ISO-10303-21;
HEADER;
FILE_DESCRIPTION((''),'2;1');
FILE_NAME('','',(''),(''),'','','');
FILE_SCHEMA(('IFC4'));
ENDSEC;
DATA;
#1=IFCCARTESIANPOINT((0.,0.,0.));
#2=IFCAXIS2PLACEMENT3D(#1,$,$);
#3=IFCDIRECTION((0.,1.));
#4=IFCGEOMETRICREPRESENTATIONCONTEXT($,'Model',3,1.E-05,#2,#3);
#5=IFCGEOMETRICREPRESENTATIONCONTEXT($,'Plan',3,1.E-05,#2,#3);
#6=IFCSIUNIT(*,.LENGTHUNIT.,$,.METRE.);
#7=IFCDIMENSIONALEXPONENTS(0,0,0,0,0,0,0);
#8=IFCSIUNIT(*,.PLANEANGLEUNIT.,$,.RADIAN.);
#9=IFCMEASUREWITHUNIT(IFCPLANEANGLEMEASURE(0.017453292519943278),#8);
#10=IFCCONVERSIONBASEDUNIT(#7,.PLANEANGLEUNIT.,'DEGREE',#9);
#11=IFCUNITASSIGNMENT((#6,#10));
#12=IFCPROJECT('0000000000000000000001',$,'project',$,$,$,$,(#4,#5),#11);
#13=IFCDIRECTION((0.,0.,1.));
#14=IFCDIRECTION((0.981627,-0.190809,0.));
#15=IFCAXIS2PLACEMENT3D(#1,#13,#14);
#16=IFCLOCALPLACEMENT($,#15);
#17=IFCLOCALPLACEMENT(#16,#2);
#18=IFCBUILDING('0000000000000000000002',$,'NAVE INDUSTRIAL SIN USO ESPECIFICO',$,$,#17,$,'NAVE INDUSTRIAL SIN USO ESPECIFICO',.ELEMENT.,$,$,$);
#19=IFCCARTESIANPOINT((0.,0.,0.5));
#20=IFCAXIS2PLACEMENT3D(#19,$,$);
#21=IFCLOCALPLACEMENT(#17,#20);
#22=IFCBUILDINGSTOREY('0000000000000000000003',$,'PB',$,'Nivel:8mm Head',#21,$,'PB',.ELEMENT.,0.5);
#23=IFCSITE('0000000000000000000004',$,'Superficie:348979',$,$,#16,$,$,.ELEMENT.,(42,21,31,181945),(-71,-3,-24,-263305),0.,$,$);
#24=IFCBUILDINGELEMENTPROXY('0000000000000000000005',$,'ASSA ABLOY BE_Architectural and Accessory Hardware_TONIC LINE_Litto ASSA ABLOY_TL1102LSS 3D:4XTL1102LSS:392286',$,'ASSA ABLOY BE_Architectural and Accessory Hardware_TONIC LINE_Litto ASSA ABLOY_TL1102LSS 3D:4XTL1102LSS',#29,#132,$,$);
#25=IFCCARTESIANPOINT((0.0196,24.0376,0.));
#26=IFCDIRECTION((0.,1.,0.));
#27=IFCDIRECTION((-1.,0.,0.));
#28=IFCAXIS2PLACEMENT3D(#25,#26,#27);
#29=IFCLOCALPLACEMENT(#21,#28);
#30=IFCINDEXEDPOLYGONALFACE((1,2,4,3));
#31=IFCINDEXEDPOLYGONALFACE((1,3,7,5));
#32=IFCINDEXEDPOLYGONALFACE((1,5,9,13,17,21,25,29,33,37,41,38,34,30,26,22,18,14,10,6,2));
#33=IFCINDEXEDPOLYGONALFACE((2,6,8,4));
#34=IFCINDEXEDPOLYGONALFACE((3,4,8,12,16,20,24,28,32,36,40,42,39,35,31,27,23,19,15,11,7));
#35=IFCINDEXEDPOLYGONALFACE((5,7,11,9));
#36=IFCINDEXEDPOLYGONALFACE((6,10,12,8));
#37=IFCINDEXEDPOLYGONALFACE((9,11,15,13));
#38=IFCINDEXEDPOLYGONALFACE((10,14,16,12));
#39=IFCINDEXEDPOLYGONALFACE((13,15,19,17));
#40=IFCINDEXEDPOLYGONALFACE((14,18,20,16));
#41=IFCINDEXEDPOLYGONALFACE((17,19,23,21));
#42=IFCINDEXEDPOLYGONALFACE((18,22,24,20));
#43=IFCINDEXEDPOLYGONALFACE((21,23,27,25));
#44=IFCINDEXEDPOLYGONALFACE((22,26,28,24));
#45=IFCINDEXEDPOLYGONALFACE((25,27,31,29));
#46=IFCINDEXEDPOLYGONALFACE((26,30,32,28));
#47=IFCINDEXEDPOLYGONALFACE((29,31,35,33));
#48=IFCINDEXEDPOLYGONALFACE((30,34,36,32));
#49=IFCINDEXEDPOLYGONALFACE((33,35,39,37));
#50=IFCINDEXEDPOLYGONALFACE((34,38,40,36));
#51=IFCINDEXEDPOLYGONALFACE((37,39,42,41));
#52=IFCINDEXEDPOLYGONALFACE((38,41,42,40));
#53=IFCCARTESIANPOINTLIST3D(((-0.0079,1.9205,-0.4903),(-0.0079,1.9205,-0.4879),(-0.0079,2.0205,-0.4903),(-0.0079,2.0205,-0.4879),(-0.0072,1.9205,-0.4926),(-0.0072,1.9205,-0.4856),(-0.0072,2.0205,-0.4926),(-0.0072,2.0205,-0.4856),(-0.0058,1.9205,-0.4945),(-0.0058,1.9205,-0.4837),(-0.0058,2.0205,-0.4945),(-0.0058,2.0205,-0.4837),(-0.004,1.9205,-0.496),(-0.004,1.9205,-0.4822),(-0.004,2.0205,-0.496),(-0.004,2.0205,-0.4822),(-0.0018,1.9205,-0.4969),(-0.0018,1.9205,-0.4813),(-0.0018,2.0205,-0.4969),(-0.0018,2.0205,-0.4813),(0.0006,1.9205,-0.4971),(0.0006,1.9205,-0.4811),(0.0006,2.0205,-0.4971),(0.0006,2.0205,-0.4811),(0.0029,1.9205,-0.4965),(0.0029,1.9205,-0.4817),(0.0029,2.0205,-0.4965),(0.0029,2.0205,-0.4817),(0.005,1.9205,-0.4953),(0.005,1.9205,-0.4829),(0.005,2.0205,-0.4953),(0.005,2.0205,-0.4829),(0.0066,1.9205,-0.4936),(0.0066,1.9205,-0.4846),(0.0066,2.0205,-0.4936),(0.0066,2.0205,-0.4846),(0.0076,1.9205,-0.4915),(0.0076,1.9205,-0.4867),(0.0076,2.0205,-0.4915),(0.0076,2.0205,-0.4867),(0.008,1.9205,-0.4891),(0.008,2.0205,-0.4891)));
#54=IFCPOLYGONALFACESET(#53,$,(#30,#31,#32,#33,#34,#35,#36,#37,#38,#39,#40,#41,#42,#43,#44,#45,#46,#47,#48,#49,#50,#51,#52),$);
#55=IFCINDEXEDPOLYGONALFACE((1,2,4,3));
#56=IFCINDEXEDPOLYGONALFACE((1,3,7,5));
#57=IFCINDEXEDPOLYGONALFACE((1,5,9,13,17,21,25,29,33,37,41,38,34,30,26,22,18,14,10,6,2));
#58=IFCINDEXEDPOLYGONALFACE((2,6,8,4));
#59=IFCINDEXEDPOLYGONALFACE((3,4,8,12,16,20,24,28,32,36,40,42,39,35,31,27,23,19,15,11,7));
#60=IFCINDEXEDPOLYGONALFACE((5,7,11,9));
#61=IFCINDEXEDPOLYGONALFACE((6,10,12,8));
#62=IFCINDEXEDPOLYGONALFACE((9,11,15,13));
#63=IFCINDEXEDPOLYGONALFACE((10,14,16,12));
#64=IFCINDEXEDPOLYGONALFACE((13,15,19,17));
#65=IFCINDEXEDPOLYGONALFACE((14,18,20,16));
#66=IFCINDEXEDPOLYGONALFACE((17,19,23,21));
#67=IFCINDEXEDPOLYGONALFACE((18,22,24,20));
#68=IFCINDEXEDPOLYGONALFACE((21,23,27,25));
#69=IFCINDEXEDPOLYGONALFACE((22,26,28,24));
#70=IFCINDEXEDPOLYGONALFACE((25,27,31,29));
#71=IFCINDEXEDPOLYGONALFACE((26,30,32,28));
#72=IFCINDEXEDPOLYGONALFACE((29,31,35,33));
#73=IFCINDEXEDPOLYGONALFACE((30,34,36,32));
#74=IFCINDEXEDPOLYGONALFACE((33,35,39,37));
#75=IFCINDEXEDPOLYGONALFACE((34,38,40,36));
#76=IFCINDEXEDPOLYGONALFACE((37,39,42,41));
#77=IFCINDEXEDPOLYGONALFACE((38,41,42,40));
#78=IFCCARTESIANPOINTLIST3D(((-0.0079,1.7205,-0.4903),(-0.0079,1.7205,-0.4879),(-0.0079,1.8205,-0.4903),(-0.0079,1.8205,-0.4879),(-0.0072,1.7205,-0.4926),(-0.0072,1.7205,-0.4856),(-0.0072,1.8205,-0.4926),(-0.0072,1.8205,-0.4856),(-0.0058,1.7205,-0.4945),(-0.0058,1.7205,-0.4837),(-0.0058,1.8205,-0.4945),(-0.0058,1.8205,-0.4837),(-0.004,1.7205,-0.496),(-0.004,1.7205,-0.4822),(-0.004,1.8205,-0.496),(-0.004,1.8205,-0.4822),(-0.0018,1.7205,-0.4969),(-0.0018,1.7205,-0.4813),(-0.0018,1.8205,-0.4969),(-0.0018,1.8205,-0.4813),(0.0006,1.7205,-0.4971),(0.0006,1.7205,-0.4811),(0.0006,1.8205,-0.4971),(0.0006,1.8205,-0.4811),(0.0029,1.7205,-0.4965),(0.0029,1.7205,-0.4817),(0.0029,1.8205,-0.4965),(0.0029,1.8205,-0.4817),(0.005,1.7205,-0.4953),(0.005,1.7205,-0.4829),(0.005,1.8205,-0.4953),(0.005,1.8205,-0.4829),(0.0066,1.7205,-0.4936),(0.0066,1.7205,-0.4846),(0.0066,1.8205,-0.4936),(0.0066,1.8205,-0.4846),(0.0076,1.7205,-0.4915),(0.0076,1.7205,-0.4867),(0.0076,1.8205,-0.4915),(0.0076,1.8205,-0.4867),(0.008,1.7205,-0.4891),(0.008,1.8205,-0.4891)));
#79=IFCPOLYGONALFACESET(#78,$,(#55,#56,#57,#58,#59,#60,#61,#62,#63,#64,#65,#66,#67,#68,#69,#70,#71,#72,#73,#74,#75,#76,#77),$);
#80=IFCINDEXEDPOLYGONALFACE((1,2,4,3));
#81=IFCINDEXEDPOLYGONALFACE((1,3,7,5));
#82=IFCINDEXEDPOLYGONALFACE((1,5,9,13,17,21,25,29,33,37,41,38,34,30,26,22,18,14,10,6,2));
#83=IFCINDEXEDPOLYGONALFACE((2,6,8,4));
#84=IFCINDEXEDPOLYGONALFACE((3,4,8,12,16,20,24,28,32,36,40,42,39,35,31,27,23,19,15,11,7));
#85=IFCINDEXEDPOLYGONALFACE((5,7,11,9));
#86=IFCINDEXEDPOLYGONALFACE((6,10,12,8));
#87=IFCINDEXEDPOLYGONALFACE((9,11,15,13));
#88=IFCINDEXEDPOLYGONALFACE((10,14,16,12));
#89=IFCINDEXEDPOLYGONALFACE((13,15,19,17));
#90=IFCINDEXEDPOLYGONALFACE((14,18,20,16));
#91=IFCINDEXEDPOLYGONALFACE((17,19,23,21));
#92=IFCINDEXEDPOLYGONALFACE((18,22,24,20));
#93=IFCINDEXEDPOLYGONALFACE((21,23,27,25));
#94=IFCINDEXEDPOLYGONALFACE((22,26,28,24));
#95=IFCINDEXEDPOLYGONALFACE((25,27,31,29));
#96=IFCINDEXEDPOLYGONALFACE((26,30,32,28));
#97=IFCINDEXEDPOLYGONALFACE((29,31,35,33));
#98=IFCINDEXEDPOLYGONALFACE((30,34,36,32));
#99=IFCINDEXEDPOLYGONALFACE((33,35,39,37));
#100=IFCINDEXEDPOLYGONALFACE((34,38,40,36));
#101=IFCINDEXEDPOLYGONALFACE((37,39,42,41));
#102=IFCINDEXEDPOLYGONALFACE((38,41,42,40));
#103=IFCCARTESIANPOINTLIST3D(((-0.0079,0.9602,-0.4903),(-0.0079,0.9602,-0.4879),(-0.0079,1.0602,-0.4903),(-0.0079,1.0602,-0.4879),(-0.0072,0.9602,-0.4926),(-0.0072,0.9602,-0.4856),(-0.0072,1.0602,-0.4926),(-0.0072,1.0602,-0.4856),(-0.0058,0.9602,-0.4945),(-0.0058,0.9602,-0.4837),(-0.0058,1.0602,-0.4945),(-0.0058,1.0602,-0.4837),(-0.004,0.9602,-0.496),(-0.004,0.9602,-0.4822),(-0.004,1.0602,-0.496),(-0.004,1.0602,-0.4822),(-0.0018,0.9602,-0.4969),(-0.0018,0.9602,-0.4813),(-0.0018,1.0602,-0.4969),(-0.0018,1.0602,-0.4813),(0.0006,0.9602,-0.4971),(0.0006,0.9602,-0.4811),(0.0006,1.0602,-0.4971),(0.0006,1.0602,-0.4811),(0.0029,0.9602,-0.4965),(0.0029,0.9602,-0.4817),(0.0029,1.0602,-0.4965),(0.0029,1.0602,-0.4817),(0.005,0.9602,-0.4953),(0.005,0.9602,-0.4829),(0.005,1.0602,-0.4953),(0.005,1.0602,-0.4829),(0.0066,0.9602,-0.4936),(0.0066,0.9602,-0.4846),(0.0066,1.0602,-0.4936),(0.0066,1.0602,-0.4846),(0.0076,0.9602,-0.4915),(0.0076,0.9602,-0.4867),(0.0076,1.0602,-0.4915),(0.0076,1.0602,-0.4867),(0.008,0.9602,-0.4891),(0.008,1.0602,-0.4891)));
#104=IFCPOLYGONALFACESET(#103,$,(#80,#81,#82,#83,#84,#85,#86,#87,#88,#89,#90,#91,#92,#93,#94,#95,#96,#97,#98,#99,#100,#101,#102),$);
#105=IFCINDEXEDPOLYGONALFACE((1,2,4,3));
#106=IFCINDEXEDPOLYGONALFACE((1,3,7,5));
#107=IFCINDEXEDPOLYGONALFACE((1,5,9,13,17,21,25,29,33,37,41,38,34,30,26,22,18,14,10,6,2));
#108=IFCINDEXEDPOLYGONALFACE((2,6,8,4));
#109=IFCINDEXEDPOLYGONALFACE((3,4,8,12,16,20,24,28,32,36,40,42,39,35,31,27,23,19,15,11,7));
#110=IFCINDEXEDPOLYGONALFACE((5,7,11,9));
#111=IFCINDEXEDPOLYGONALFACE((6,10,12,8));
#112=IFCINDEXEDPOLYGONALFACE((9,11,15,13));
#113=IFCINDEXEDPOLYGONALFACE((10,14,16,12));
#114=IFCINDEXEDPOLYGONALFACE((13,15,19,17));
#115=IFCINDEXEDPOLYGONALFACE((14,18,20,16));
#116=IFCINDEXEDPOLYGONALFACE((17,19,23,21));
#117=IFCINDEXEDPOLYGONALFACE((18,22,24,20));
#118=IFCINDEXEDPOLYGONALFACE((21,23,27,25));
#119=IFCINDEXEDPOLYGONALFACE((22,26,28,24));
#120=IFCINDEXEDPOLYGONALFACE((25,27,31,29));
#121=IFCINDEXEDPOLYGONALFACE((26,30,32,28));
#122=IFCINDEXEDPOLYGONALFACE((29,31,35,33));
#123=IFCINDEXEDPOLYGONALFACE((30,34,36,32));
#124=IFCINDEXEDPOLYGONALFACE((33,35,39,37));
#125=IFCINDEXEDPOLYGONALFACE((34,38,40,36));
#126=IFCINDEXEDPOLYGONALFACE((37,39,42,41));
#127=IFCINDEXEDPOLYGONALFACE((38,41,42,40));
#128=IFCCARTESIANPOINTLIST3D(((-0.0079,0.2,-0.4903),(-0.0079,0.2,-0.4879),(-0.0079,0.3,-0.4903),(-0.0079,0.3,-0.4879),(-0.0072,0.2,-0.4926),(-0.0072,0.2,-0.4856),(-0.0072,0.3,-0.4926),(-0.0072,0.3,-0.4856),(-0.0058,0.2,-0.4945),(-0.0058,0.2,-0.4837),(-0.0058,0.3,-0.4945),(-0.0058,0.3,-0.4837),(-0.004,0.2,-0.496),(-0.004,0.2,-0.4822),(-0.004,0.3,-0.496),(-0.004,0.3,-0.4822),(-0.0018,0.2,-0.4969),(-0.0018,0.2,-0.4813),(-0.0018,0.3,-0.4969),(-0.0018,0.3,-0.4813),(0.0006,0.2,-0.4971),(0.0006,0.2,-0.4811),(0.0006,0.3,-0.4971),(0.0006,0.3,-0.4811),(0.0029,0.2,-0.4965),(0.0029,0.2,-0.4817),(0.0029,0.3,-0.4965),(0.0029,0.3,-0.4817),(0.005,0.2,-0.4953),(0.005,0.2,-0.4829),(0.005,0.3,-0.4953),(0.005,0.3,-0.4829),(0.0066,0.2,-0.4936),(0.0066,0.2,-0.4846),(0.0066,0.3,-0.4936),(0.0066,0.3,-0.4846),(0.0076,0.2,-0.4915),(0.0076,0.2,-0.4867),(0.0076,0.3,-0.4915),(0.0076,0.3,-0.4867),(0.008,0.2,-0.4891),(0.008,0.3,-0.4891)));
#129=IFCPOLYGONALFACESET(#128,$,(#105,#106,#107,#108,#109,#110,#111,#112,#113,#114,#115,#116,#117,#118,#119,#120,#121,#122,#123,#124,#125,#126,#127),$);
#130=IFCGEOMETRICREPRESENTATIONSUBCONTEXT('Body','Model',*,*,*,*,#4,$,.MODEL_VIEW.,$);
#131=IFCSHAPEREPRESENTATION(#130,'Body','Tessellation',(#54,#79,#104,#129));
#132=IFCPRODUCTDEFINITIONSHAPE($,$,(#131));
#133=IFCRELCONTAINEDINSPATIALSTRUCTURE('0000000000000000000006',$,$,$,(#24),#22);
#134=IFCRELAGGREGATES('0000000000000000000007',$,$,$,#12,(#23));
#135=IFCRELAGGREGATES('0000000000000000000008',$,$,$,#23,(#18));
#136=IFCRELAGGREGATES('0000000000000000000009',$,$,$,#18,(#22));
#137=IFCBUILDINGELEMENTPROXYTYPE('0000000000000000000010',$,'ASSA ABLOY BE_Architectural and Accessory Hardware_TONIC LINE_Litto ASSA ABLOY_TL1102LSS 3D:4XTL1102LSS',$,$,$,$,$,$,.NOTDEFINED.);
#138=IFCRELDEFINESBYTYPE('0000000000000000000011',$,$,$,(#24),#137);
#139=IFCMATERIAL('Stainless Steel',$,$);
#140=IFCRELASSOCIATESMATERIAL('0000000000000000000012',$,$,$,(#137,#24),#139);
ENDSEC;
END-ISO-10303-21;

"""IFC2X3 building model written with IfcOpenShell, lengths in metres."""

from ifc_helpers import new_model, entity, si_unit, converted_unit, direction, frame, frame_2d, origin, place, context, subcontext, project, spatial, circle, extrude, source, transform, mapped, material, type_object, type_shapes, element, save


model = new_model("IFC2X3")

# Units and contexts
model_context = context("Model", 3, precision=1e-05, world=origin(), true_north=direction((0.0, 1.0)))
plan_context = context("Plan", 3, precision=1e-05, world=origin(), true_north=direction((0.0, 1.0)))
body_context = subcontext(model_context, "Body", "Model", "MODEL_VIEW")
ifc_project = project(units=[si_unit("LENGTHUNIT", "METRE"), converted_unit("PLANEANGLEUNIT", "DEGREE", entity("IfcPlaneAngleMeasure", 0.017453292519943278), si_unit("PLANEANGLEUNIT", "RADIAN"), dimensions=[0, 0, 0, 0, 0, 0, 0])], contexts=[model_context, plan_context])

# Site, building, storey
site_placement = place(None, frame((0.0, 0.0, 0.0), z_axis=(0.0, 0.0, 1.0), x_axis=(0.981627, -0.190809, 0.0)))
site = spatial("IfcSite", under=ifc_project, at=site_placement, Name="Superficie:348979", CompositionType="ELEMENT", RefLatitude=(42, 21, 31, 181945), RefLongitude=(-71, -3, -24, -263305), RefElevation=0.0)
building_placement = place(site_placement, origin())
building = spatial("IfcBuilding", under=site, at=building_placement, Name="NAVE INDUSTRIAL SIN USO ESPECIFICO", LongName="NAVE INDUSTRIAL SIN USO ESPECIFICO", CompositionType="ELEMENT")
storey_placement = place(building_placement, frame((0.0, 0.0, 0.5)))
storey = spatial("IfcBuildingStorey", under=building, at=storey_placement, Name="PB", ObjectType="Nivel:8mm Head", LongName="PB", CompositionType="ELEMENT", Elevation=0.5)

# Building element proxy
ifc_material_1 = material(Name="Stainless Steel")
building_element_proxy_type_1 = type_object("IfcBuildingElementProxyType", Name="ASSA ABLOY BE_Architectural and Accessory Hardware_TONIC LINE_Litto ASSA ABLOY_TL1102LSS 3D:4XTL1102LSS", PredefinedType="NOTDEFINED", material=ifc_material_1)
shared_shape_1 = source(origin(), body_context, "Body", "SweptSolid", [
    extrude(circle(Radius=0.008, at=frame_2d((0.0, 0.0), x_axis=(1.0, 0.0))), frame((0.0, 1.9205, -0.4891), z_axis=(0.0, 1.0, 0.0), x_axis=(1.0, 0.0, 0.0)), (0.0, 0.0, 1.0), 0.1),
    extrude(circle(Radius=0.008, at=frame_2d((0.0, 0.0), x_axis=(1.0, 0.0))), frame((0.0, 1.7205, -0.4891), z_axis=(0.0, 1.0, 0.0), x_axis=(1.0, 0.0, 0.0)), (0.0, 0.0, 1.0), 0.1),
    extrude(circle(Radius=0.008, at=frame_2d((0.0, 0.0), x_axis=(1.0, 0.0))), frame((0.0, 0.9602, -0.4891), z_axis=(0.0, 1.0, 0.0), x_axis=(1.0, 0.0, 0.0)), (0.0, 0.0, 1.0), 0.1),
    extrude(circle(Radius=0.008, at=frame_2d((0.0, 0.0), x_axis=(1.0, 0.0))), frame((0.0, 0.2, -0.4891), z_axis=(0.0, 1.0, 0.0), x_axis=(1.0, 0.0, 0.0)), (0.0, 0.0, 1.0), 0.1),
])
type_shapes(building_element_proxy_type_1, [shared_shape_1])
for number, where, z_axis, x_axis, name in (
    (1, (0.0196, 24.0376, 0.0), (0.0, 1.0, 0.0), (-1.0, 0.0, 0.0), "ASSA ABLOY BE_Architectural and Accessory Hardware_TONIC LINE_Litto ASSA ABLOY_TL1102LSS 3D:4XTL1102LSS:392286"),
):
    element("IfcBuildingElementProxy", number, at=place(storey_placement, frame(where, z_axis=z_axis, x_axis=x_axis)), inside=storey, type_object=building_element_proxy_type_1, material=ifc_material_1, Name=name, ObjectType="ASSA ABLOY BE_Architectural and Accessory Hardware_TONIC LINE_Litto ASSA ABLOY_TL1102LSS 3D:4XTL1102LSS", context=body_context, shape_type="MappedRepresentation", body=[
        mapped(shared_shape_1, transform((0.0, 0.0, 0.0), scale=1.0)),
    ])

save(model, "model.ifc")
